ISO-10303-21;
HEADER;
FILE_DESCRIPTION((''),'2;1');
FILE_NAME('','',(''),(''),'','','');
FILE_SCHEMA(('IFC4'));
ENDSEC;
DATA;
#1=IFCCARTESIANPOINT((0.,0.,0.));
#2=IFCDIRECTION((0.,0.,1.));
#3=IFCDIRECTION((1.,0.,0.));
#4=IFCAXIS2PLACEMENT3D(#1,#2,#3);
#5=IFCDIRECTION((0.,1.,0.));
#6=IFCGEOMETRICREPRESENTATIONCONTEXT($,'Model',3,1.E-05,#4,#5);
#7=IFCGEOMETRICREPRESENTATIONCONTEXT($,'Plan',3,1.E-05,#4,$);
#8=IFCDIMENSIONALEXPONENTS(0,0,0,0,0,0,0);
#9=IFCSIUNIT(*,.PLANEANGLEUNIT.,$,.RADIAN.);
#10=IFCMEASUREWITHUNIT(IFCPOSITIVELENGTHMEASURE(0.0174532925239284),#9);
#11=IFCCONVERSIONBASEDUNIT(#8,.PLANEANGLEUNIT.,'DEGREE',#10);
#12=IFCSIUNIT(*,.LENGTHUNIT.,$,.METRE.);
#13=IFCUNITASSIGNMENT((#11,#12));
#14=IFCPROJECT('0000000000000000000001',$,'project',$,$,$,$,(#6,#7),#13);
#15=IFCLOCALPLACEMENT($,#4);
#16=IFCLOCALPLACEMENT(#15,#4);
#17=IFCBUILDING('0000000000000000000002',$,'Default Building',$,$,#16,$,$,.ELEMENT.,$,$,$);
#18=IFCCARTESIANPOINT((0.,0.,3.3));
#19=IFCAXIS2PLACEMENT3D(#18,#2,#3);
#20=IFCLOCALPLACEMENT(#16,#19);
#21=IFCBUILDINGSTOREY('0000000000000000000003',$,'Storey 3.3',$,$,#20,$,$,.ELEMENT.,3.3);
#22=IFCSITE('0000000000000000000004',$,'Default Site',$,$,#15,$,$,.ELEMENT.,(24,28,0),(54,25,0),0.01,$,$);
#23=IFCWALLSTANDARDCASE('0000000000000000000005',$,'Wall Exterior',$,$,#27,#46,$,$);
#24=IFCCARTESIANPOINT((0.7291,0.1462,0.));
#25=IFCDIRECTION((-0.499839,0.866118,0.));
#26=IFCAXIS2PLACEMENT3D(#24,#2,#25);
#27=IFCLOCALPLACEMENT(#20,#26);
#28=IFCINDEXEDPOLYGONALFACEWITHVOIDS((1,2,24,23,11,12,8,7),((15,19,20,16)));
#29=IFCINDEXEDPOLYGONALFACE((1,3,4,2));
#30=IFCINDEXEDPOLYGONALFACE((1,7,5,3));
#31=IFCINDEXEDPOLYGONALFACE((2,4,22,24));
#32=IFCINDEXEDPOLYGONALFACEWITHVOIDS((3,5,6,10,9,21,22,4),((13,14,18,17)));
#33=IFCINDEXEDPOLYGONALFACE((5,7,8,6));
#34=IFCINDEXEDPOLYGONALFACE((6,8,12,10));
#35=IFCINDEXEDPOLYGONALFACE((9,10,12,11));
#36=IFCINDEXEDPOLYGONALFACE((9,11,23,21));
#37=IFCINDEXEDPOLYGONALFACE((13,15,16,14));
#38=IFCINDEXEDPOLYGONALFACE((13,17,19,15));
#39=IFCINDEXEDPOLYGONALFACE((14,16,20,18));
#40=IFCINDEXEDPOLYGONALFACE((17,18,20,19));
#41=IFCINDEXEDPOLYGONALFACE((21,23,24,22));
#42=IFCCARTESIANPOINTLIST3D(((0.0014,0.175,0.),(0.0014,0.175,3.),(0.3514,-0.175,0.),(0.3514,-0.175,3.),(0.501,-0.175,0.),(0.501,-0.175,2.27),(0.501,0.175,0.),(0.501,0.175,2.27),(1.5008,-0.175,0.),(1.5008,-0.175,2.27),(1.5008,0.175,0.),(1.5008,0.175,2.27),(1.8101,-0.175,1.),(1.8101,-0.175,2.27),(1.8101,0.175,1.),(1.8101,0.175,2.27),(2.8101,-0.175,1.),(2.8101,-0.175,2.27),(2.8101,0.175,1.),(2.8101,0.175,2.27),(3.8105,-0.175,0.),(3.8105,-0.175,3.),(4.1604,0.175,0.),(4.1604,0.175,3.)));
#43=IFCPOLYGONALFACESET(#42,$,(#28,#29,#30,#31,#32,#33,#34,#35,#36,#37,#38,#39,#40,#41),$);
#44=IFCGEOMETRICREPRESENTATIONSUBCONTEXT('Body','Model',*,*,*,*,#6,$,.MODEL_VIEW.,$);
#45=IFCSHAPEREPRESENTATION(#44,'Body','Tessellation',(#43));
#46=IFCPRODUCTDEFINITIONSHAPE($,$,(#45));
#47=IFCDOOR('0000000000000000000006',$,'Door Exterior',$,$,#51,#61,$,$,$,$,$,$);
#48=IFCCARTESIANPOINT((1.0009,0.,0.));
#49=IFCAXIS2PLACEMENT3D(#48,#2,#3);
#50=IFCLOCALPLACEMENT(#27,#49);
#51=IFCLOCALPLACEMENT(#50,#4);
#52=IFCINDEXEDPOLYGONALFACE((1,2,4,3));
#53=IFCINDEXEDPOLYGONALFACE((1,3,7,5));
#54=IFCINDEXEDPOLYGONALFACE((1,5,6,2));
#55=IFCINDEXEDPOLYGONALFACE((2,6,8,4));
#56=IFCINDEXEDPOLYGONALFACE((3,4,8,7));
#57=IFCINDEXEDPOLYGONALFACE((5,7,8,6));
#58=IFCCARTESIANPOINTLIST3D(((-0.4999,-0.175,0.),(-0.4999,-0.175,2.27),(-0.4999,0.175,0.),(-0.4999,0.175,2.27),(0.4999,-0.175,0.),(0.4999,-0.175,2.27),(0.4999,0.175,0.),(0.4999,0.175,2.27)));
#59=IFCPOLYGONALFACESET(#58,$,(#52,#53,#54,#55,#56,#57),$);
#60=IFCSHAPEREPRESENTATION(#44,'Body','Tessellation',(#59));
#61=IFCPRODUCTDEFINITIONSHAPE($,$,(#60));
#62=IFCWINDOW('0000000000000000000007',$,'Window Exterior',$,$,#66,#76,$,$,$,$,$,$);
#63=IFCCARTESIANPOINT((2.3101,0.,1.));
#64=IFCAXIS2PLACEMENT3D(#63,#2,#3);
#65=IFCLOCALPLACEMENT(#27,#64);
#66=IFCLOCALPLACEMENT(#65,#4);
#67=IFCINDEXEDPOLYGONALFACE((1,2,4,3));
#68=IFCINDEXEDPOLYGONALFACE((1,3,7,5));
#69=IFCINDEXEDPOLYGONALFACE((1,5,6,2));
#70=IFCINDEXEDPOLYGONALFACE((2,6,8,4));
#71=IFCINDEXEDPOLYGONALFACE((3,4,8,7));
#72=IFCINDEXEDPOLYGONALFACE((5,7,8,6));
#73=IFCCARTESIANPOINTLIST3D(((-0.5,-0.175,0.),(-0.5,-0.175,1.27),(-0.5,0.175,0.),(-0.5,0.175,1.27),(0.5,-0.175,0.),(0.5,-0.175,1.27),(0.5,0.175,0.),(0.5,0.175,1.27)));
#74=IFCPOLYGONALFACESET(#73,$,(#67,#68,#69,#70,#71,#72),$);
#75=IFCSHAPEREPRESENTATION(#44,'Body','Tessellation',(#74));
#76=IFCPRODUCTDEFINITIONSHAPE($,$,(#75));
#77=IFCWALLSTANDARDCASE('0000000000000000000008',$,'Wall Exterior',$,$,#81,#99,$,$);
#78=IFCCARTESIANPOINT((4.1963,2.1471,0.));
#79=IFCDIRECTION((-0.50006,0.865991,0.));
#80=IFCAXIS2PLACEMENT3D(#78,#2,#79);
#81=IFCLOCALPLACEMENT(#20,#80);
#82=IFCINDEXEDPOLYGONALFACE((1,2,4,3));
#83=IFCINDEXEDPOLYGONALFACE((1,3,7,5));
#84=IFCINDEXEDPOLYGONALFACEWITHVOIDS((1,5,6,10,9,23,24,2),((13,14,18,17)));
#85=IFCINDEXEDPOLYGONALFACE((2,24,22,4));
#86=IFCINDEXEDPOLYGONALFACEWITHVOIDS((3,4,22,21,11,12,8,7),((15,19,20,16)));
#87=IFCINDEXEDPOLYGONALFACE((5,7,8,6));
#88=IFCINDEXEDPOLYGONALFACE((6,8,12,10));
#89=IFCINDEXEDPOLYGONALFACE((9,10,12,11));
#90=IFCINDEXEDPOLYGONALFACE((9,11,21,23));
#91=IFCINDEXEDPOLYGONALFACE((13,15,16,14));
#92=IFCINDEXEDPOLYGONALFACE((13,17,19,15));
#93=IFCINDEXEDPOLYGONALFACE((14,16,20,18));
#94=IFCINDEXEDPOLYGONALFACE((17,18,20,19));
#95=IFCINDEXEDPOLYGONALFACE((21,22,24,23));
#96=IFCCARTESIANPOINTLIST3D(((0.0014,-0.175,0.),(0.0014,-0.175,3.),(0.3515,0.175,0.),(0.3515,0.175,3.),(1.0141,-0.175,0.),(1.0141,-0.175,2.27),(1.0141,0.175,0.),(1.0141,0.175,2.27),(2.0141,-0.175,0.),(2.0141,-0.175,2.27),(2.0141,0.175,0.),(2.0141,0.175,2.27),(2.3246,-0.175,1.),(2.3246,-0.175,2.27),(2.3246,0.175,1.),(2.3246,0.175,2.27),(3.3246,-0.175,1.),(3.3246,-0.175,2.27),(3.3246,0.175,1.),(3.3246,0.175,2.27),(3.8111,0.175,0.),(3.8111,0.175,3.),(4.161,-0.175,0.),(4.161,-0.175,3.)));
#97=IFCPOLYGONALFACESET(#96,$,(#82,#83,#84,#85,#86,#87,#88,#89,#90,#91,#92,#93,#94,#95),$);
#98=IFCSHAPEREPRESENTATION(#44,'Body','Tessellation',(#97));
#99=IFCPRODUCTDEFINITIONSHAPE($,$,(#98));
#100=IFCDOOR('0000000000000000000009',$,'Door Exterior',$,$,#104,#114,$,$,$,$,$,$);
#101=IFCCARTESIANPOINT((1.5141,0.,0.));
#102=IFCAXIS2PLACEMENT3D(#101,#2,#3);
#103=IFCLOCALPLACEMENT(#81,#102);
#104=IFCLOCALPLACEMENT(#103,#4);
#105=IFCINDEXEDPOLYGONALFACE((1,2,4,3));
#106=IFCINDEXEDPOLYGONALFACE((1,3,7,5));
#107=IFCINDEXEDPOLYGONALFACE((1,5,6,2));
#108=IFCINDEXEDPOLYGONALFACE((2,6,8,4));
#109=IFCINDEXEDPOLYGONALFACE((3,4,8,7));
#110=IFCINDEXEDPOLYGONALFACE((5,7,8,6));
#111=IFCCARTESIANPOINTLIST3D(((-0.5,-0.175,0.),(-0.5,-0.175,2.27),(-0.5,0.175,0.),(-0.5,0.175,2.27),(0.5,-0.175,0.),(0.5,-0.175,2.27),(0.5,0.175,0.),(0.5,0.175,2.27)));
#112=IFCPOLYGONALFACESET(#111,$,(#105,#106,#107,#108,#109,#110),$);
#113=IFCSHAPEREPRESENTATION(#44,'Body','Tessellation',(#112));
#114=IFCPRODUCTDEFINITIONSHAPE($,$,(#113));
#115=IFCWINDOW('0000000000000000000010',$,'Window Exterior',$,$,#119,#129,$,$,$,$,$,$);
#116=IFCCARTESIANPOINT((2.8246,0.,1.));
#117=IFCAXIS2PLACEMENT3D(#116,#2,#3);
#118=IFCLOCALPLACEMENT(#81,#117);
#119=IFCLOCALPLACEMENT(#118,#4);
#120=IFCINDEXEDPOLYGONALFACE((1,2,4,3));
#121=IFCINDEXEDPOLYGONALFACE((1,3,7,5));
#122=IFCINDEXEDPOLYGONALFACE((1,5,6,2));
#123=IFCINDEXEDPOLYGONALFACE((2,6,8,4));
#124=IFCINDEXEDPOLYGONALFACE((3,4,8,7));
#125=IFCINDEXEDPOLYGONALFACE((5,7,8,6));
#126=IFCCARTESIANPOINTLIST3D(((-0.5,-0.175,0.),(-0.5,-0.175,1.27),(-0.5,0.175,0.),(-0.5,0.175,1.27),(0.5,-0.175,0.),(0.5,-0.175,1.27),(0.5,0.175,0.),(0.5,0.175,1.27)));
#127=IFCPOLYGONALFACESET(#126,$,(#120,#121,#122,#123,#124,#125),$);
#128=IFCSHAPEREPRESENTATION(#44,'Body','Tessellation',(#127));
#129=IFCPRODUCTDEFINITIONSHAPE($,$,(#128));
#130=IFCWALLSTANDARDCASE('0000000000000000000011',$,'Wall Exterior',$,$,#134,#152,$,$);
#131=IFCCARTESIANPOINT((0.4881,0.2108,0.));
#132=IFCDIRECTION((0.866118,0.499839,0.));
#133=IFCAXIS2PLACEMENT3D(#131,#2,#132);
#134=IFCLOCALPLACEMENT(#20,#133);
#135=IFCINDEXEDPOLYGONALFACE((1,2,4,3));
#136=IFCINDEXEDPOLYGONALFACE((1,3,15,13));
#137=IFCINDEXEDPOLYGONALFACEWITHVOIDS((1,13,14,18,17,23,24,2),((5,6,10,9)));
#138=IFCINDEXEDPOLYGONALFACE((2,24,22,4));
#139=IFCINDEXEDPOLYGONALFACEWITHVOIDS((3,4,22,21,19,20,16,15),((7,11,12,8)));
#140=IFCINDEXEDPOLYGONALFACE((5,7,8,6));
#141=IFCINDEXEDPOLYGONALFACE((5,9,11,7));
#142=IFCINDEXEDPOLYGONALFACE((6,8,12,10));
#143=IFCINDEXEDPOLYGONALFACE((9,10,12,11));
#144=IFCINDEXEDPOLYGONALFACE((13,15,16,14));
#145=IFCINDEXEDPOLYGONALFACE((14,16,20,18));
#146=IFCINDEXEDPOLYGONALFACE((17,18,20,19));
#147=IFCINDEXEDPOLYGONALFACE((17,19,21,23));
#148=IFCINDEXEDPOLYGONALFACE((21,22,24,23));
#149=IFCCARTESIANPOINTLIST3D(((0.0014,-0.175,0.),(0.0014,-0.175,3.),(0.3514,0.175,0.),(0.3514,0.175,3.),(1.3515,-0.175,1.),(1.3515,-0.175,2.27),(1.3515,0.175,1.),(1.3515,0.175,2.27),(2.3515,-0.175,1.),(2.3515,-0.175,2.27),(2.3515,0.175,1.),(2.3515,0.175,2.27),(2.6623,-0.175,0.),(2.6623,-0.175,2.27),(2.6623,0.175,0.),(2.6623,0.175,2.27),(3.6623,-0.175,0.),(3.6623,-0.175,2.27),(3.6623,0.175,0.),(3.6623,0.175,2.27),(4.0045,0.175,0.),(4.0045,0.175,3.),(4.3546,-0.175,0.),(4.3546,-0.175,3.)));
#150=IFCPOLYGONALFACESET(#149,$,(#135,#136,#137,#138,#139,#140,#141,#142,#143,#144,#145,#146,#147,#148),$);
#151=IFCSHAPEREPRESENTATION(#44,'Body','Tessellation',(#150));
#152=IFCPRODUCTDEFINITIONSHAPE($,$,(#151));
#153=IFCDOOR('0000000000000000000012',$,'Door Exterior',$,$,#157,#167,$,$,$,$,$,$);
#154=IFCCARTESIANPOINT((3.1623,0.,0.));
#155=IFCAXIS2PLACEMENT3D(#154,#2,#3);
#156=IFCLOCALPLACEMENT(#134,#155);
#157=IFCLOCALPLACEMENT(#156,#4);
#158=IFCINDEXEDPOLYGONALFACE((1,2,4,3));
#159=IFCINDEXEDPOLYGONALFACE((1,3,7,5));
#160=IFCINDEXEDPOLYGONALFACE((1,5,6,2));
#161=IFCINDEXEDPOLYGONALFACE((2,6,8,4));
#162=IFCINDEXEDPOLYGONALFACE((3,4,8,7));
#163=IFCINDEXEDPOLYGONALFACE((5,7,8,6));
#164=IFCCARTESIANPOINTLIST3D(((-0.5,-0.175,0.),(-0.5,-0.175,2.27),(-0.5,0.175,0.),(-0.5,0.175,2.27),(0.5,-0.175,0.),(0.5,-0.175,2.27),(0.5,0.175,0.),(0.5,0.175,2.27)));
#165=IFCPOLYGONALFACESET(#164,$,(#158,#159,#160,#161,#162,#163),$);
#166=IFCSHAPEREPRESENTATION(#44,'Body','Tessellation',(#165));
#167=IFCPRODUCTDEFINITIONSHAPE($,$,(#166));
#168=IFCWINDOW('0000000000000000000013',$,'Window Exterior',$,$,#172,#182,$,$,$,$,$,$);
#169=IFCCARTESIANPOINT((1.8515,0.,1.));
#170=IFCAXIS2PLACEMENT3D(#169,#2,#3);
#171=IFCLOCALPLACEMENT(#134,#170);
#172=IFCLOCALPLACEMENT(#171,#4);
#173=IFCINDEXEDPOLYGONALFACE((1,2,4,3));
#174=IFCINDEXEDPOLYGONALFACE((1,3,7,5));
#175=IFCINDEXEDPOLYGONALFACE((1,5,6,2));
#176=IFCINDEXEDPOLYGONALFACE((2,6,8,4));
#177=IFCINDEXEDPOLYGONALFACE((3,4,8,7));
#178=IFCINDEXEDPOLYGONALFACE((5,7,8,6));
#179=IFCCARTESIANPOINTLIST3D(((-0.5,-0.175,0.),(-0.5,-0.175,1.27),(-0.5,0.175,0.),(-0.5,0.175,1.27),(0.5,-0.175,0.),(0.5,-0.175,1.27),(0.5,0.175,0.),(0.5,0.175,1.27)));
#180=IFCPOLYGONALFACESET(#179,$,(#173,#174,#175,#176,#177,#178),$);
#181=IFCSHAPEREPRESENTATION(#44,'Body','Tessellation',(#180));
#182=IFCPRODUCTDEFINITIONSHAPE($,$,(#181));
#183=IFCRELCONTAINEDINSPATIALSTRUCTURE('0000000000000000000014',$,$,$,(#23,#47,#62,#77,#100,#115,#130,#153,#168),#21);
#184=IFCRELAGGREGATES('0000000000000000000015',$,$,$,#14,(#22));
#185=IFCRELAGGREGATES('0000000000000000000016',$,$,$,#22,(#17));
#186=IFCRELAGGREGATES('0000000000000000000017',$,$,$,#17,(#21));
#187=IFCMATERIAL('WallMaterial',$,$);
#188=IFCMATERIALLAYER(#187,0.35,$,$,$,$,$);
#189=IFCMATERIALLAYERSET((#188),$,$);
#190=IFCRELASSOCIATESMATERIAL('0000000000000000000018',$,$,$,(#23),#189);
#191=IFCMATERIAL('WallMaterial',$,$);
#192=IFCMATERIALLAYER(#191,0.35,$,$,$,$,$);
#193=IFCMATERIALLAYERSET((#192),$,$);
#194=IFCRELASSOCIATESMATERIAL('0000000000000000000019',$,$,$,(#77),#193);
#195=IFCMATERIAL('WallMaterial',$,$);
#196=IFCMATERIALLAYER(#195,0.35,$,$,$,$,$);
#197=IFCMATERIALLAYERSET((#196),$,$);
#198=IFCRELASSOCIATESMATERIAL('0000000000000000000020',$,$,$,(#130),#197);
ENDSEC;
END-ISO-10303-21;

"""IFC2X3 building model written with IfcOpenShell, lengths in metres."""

from ifc_helpers import new_model, entity, si_unit, converted_unit, direction, frame, origin_with_axes, place, context, subcontext, project, spatial, polyline, outline, extrude, material, layer, layer_set, layer_usage, element, fill, save


model = new_model("IFC2X3")

# Units and contexts
model_context = context("Model", 3, precision=1e-05, world=origin_with_axes(), true_north=direction((0.0, 1.0, 0.0)))
plan_context = context("Plan", 3, precision=1e-05, world=origin_with_axes())
body_context = subcontext(model_context, "Body", "Model", "MODEL_VIEW")
ifc_project = project(units=[converted_unit("PLANEANGLEUNIT", "DEGREE", entity("IfcPositiveLengthMeasure", 0.0174532925239284), si_unit("PLANEANGLEUNIT", "RADIAN"), dimensions=[0, 0, 0, 0, 0, 0, 0]), si_unit("LENGTHUNIT", "METRE")], contexts=[model_context, plan_context])

# Site, building, storey
site_placement = place(None, origin_with_axes())
site = spatial("IfcSite", under=ifc_project, at=site_placement, Name="Default Site", CompositionType="ELEMENT", RefLatitude=(24, 28, 0), RefLongitude=(54, 25, 0), RefElevation=0.01)
building_placement = place(site_placement, origin_with_axes())
building = spatial("IfcBuilding", under=site, at=building_placement, Name="Default Building", CompositionType="ELEMENT")
storey_placement = place(building_placement, frame((0.0, 0.0, 3.3), z_axis=(0.0, 0.0, 1.0), x_axis=(1.0, 0.0, 0.0)))
storey = spatial("IfcBuildingStorey", under=building, at=storey_placement, Name="Storey 3.3", CompositionType="ELEMENT", Elevation=3.3)

# Walls, openings, doors, windows
ifc_material_1 = material(Name="WallMaterial")
ifc_layer_1 = layer(ifc_material_1, 0.35)
ifc_layer_set_1 = layer_set([ifc_layer_1])
ifc_layer_usage_1 = layer_usage(ifc_layer_set_1, "AXIS2", "POSITIVE", -0.175)
wall_1_placement = place(storey_placement, frame((0.7291, 0.1462, 0.0), z_axis=(0.0, 0.0, 1.0), x_axis=(-0.499839, 0.866118, 0.0)))
wall_1 = element("IfcWallStandardCase", 1, at=wall_1_placement, inside=storey, material=ifc_layer_usage_1, Name="Wall Exterior", context=body_context, shape_type="SweptSolid", body=[
    extrude(outline(polyline([(0.3514, -0.175), (3.8105, -0.175), (4.1604, 0.175), (0.0014, 0.175), (0.3514, -0.175)])), origin_with_axes(), (0.0, 0.0, 1.0), 3.0),
])
opening_1_placement = place(wall_1_placement, frame((1.0009, 0.0, 0.0), z_axis=(0.0, 0.0, 1.0), x_axis=(1.0, 0.0, 0.0)))
opening_1 = element("IfcOpeningElement", 2, at=opening_1_placement, cuts=wall_1, context=body_context, shape_type="SweptSolid", body=[
    extrude(outline(polyline([(-0.4999, 0.372), (0.4999, 0.372), (0.4999, -0.372), (-0.4999, -0.372), (-0.4999, 0.372)])), origin_with_axes(), (0.0, 0.0, 1.0), 2.27),
])
opening_2_placement = place(wall_1_placement, frame((2.3101, 0.0, 1.0), z_axis=(0.0, 0.0, 1.0), x_axis=(1.0, 0.0, 0.0)))
opening_2 = element("IfcOpeningElement", 3, at=opening_2_placement, cuts=wall_1, context=body_context, shape_type="SweptSolid", body=[
    extrude(outline(polyline([(-0.5, 0.372), (0.5, 0.372), (0.5, -0.372), (-0.5, -0.372), (-0.5, 0.372)])), origin_with_axes(), (0.0, 0.0, 1.0), 1.27),
])
door_1_placement = place(opening_1_placement, origin_with_axes())
door_1 = element("IfcDoor", 4, at=door_1_placement, inside=storey, Name="Door Exterior", context=body_context, shape_type="SweptSolid", body=[
    extrude(outline(polyline([(-0.4999, 0.175), (0.4999, 0.175), (0.4999, -0.175), (-0.4999, -0.175), (-0.4999, 0.175)])), origin_with_axes(), (0.0, 0.0, 1.0), 2.27),
])
fill(opening_1, door_1)
window_1_placement = place(opening_2_placement, origin_with_axes())
window_1 = element("IfcWindow", 5, at=window_1_placement, inside=storey, Name="Window Exterior", context=body_context, shape_type="SweptSolid", body=[
    extrude(outline(polyline([(-0.5, 0.175), (0.5, 0.175), (0.5, -0.175), (-0.5, -0.175), (-0.5, 0.175)])), origin_with_axes(), (0.0, 0.0, 1.0), 1.27),
])
fill(opening_2, window_1)
ifc_material_2 = material(Name="WallMaterial")
ifc_layer_2 = layer(ifc_material_2, 0.35)
ifc_layer_set_2 = layer_set([ifc_layer_2])
ifc_layer_usage_2 = layer_usage(ifc_layer_set_2, "AXIS2", "POSITIVE", -0.175)
wall_2_placement = place(storey_placement, frame((4.1963, 2.1471, 0.0), z_axis=(0.0, 0.0, 1.0), x_axis=(-0.50006, 0.865991, 0.0)))
wall_2 = element("IfcWallStandardCase", 6, at=wall_2_placement, inside=storey, material=ifc_layer_usage_2, Name="Wall Exterior", context=body_context, shape_type="SweptSolid", body=[
    extrude(outline(polyline([(4.161, -0.175), (3.8111, 0.175), (0.3515, 0.175), (0.0014, -0.175), (4.161, -0.175)])), origin_with_axes(), (0.0, 0.0, 1.0), 3.0),
])
opening_3_placement = place(wall_2_placement, frame((1.5141, 0.0, 0.0), z_axis=(0.0, 0.0, 1.0), x_axis=(1.0, 0.0, 0.0)))
opening_3 = element("IfcOpeningElement", 7, at=opening_3_placement, cuts=wall_2, context=body_context, shape_type="SweptSolid", body=[
    extrude(outline(polyline([(-0.5, 0.372), (0.5, 0.372), (0.5, -0.372), (-0.5, -0.372), (-0.5, 0.372)])), origin_with_axes(), (0.0, 0.0, 1.0), 2.27),
])
opening_4_placement = place(wall_2_placement, frame((2.8246, 0.0, 1.0), z_axis=(0.0, 0.0, 1.0), x_axis=(1.0, 0.0, 0.0)))
opening_4 = element("IfcOpeningElement", 8, at=opening_4_placement, cuts=wall_2, context=body_context, shape_type="SweptSolid", body=[
    extrude(outline(polyline([(-0.5, 0.372), (0.5, 0.372), (0.5, -0.372), (-0.5, -0.372), (-0.5, 0.372)])), origin_with_axes(), (0.0, 0.0, 1.0), 1.27),
])
door_2_placement = place(opening_3_placement, origin_with_axes())
door_2 = element("IfcDoor", 9, at=door_2_placement, inside=storey, Name="Door Exterior", context=body_context, shape_type="SweptSolid", body=[
    extrude(outline(polyline([(-0.5, 0.175), (0.5, 0.175), (0.5, -0.175), (-0.5, -0.175), (-0.5, 0.175)])), origin_with_axes(), (0.0, 0.0, 1.0), 2.27),
])
fill(opening_3, door_2)
window_2_placement = place(opening_4_placement, origin_with_axes())
window_2 = element("IfcWindow", 10, at=window_2_placement, inside=storey, Name="Window Exterior", context=body_context, shape_type="SweptSolid", body=[
    extrude(outline(polyline([(-0.5, 0.175), (0.5, 0.175), (0.5, -0.175), (-0.5, -0.175), (-0.5, 0.175)])), origin_with_axes(), (0.0, 0.0, 1.0), 1.27),
])
fill(opening_4, window_2)
ifc_material_3 = material(Name="WallMaterial")
ifc_layer_3 = layer(ifc_material_3, 0.35)
ifc_layer_set_3 = layer_set([ifc_layer_3])
ifc_layer_usage_3 = layer_usage(ifc_layer_set_3, "AXIS2", "POSITIVE", -0.175)
wall_3_placement = place(storey_placement, frame((0.4881, 0.2108, 0.0), z_axis=(0.0, 0.0, 1.0), x_axis=(0.866118, 0.499839, 0.0)))
wall_3 = element("IfcWallStandardCase", 11, at=wall_3_placement, inside=storey, material=ifc_layer_usage_3, Name="Wall Exterior", context=body_context, shape_type="SweptSolid", body=[
    extrude(outline(polyline([(4.3546, -0.175), (4.0045, 0.175), (0.3514, 0.175), (0.0014, -0.175), (4.3546, -0.175)])), origin_with_axes(), (0.0, 0.0, 1.0), 3.0),
])
opening_5_placement = place(wall_3_placement, frame((3.1623, 0.0, 0.0), z_axis=(0.0, 0.0, 1.0), x_axis=(1.0, 0.0, 0.0)))
opening_5 = element("IfcOpeningElement", 12, at=opening_5_placement, cuts=wall_3, context=body_context, shape_type="SweptSolid", body=[
    extrude(outline(polyline([(-0.5, 0.372), (0.5, 0.372), (0.5, -0.372), (-0.5, -0.372), (-0.5, 0.372)])), origin_with_axes(), (0.0, 0.0, 1.0), 2.27),
])
opening_6_placement = place(wall_3_placement, frame((1.8515, 0.0, 1.0), z_axis=(0.0, 0.0, 1.0), x_axis=(1.0, 0.0, 0.0)))
opening_6 = element("IfcOpeningElement", 13, at=opening_6_placement, cuts=wall_3, context=body_context, shape_type="SweptSolid", body=[
    extrude(outline(polyline([(-0.5, 0.372), (0.5, 0.372), (0.5, -0.372), (-0.5, -0.372), (-0.5, 0.372)])), origin_with_axes(), (0.0, 0.0, 1.0), 1.27),
])
door_3_placement = place(opening_5_placement, origin_with_axes())
door_3 = element("IfcDoor", 14, at=door_3_placement, inside=storey, Name="Door Exterior", context=body_context, shape_type="SweptSolid", body=[
    extrude(outline(polyline([(-0.5, 0.175), (0.5, 0.175), (0.5, -0.175), (-0.5, -0.175), (-0.5, 0.175)])), origin_with_axes(), (0.0, 0.0, 1.0), 2.27),
])
fill(opening_5, door_3)
window_3_placement = place(opening_6_placement, origin_with_axes())
window_3 = element("IfcWindow", 15, at=window_3_placement, inside=storey, Name="Window Exterior", context=body_context, shape_type="SweptSolid", body=[
    extrude(outline(polyline([(-0.5, 0.175), (0.5, 0.175), (0.5, -0.175), (-0.5, -0.175), (-0.5, 0.175)])), origin_with_axes(), (0.0, 0.0, 1.0), 1.27),
])
fill(opening_6, window_3)

save(model, "model.ifc")
